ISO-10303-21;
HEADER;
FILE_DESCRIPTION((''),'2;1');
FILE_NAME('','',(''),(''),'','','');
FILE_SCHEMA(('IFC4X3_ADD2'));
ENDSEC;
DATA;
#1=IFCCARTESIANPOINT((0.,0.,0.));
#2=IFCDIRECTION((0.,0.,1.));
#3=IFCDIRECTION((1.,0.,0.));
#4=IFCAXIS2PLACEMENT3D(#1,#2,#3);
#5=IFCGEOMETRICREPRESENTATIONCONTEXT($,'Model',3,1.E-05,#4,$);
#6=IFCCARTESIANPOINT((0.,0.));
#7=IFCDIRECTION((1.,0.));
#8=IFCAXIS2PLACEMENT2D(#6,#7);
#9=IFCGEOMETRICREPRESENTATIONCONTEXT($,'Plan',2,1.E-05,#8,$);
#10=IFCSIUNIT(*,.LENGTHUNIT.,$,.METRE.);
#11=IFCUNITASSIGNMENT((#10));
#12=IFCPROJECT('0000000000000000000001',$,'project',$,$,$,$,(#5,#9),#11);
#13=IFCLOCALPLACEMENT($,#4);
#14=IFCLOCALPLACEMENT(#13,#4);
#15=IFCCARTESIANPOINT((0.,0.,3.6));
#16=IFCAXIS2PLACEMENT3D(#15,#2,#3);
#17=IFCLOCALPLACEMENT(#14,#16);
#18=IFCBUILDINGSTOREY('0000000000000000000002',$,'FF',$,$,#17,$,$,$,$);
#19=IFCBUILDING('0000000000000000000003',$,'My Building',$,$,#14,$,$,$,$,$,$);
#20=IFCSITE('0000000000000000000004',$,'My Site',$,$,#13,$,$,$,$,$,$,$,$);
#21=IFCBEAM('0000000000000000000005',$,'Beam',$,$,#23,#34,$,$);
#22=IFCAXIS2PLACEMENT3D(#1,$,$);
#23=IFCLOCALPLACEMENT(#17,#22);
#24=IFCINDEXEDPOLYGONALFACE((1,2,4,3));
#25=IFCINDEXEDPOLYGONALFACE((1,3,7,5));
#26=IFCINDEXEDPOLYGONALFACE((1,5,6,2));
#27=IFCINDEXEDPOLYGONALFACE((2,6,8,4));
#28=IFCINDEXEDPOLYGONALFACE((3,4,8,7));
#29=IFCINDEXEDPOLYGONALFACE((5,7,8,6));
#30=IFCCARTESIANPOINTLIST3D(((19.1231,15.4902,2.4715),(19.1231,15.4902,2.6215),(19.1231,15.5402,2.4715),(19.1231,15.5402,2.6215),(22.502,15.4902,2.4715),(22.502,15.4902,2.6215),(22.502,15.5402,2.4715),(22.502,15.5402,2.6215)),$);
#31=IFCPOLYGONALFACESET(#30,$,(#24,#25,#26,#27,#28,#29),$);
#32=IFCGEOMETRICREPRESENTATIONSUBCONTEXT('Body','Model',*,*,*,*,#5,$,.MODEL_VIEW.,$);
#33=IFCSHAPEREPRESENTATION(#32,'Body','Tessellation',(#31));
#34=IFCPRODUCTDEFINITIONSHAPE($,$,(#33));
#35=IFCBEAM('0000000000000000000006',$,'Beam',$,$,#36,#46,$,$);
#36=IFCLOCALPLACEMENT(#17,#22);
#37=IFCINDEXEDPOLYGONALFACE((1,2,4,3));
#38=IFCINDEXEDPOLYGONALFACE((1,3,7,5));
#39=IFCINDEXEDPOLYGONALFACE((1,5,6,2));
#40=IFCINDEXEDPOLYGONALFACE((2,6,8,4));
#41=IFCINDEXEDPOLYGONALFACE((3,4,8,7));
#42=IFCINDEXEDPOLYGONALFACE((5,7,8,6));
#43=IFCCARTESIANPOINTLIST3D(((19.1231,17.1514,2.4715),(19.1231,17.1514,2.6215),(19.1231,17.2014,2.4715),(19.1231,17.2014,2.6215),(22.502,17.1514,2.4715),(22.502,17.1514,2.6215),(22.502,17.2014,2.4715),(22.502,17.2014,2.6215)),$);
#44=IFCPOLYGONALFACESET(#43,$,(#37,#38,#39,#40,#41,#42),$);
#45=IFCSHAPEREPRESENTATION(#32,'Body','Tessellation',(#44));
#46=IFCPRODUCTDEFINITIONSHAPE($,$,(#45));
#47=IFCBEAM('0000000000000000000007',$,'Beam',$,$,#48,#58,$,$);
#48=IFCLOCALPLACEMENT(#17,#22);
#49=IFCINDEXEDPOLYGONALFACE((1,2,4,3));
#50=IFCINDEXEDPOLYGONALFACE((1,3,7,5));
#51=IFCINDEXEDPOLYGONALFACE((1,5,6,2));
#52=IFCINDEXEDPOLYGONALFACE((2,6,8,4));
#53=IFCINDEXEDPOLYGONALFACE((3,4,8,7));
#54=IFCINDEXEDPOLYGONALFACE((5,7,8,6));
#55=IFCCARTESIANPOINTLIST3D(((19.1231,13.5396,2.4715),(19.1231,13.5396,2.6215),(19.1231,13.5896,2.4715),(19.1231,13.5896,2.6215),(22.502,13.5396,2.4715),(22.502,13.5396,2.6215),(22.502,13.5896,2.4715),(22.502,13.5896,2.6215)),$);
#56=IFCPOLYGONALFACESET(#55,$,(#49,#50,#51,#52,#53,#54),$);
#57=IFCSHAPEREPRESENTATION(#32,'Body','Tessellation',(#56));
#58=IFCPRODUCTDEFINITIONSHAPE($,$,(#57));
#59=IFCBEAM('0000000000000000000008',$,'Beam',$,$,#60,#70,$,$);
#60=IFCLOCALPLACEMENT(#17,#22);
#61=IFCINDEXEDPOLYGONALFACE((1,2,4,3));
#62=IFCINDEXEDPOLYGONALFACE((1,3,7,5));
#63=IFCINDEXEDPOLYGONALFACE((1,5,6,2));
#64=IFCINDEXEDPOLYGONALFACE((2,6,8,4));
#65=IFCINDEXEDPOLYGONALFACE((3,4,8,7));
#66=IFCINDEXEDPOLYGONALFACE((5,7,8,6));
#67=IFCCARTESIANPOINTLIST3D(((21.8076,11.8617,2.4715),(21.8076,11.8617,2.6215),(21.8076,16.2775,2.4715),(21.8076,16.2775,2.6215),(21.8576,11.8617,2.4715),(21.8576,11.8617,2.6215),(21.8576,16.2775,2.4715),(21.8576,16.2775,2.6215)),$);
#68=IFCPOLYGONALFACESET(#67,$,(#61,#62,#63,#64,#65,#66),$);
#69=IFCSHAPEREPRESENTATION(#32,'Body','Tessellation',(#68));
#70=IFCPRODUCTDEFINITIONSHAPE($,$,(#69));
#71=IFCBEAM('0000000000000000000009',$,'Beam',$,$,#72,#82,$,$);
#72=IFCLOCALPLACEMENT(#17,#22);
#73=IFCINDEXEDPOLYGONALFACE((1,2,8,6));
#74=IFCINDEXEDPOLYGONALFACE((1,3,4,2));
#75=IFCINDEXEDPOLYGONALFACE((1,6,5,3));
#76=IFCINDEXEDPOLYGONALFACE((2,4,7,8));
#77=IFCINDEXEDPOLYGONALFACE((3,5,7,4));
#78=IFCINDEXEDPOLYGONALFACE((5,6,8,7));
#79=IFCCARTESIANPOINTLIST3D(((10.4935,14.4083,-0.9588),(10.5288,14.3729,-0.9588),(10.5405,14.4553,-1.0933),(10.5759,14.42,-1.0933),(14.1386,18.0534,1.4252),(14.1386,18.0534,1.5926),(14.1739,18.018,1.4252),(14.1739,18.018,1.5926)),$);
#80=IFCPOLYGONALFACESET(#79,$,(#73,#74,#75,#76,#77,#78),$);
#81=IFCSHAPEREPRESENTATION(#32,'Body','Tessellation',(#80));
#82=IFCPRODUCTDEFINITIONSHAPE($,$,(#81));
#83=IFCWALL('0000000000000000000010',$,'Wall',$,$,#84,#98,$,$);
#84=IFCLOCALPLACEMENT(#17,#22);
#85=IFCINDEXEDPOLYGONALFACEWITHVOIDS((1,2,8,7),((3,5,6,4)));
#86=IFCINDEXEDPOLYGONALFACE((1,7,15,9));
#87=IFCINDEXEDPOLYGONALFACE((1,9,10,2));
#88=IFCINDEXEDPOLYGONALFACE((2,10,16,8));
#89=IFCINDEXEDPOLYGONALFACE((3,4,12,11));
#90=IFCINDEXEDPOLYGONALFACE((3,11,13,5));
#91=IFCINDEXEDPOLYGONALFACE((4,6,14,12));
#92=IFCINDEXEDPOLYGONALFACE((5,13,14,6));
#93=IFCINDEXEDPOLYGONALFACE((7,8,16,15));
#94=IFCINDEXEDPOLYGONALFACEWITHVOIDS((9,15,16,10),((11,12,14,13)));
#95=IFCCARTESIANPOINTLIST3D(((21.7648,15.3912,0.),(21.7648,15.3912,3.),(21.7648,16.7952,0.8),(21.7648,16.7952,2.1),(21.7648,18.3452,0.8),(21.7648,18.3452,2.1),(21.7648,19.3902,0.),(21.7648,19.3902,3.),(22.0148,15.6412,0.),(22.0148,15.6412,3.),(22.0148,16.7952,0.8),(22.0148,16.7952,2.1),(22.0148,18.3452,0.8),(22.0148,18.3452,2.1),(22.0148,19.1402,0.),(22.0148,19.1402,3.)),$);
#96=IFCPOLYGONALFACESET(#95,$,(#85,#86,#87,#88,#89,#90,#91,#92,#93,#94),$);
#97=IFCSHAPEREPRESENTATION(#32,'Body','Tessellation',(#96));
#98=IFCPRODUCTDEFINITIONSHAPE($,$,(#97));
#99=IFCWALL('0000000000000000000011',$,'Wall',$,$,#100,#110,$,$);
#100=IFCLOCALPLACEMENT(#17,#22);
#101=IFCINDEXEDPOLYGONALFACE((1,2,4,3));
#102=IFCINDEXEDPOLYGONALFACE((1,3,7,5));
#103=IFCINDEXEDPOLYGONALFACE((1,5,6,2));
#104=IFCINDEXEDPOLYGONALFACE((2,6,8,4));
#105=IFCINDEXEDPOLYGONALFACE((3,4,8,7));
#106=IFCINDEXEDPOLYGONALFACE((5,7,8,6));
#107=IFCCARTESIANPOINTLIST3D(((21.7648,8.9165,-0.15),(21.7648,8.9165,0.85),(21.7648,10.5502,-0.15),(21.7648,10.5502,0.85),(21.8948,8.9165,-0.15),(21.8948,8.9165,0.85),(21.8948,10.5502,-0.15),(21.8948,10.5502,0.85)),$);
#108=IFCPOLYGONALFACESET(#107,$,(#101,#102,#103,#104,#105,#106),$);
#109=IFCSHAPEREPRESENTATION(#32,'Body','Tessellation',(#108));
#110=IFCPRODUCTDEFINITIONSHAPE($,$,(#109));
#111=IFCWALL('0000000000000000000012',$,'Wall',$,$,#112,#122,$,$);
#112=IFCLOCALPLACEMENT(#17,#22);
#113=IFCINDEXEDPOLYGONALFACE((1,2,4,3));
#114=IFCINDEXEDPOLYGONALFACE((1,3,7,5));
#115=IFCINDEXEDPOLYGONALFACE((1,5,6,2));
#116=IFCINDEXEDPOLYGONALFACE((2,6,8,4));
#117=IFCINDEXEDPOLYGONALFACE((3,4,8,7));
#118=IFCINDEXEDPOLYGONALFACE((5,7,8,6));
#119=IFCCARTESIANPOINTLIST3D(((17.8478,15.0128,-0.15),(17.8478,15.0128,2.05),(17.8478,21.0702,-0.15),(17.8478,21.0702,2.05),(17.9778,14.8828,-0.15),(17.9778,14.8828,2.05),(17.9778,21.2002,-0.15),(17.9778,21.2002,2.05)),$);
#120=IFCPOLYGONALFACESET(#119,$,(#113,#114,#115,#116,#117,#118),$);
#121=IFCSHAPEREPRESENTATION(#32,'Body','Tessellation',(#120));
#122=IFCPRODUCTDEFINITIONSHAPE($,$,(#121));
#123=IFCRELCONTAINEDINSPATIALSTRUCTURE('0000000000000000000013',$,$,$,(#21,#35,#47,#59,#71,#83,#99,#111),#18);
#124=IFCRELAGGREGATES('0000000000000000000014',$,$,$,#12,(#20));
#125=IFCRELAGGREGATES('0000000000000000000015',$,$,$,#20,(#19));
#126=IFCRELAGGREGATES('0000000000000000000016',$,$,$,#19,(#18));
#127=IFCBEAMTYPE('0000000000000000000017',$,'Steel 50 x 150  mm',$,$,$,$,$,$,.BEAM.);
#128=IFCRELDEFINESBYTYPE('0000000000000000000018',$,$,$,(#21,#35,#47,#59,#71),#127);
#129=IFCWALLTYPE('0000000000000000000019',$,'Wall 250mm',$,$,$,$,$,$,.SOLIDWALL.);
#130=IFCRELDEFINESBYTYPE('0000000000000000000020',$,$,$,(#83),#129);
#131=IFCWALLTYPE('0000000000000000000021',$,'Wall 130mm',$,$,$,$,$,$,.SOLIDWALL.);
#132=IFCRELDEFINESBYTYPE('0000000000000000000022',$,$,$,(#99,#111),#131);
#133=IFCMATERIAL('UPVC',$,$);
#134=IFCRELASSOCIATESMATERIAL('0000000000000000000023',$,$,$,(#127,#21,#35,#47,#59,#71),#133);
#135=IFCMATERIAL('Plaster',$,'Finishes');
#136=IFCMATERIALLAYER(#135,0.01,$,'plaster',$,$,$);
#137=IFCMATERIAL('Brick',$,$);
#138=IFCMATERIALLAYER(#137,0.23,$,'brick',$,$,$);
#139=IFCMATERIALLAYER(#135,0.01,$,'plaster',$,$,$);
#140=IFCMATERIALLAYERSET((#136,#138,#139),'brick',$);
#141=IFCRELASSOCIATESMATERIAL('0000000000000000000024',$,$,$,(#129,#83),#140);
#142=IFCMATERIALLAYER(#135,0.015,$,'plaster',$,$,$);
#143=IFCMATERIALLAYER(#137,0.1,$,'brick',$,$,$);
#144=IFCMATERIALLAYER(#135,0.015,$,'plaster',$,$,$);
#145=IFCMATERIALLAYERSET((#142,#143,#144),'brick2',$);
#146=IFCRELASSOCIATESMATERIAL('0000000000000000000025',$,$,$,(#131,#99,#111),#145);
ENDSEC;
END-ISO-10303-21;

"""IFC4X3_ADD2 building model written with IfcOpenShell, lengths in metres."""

from ifc_helpers import new_model, si_unit, frame, origin_with_axes, origin_2d_with_axis, place, context, subcontext, project, spatial, line, indexed_curve, rectangle, outline, extrude, clip, halfspace, source, transform, mapped, material, layer, layer_set, layer_usage, material_profile, profile_set, profile_usage, type_object, element, save


model = new_model("IFC4X3_ADD2")

# Units and contexts
model_context = context("Model", 3, precision=1e-05, world=origin_with_axes())
plan_context = context("Plan", 2, precision=1e-05, world=origin_2d_with_axis())
body_context = subcontext(model_context, "Body", "Model", "MODEL_VIEW")
ifc_project = project(units=[si_unit("LENGTHUNIT", "METRE")], contexts=[model_context, plan_context])

# Site, building, storey
site_placement = place(None, origin_with_axes())
site = spatial("IfcSite", under=ifc_project, at=site_placement, Name="My Site")
building_placement = place(site_placement, origin_with_axes())
building = spatial("IfcBuilding", under=site, at=building_placement, Name="My Building")
storey_placement = place(building_placement, frame((0.0, 0.0, 3.6), z_axis=(0.0, 0.0, 1.0), x_axis=(1.0, 0.0, 0.0)))
storey = spatial("IfcBuildingStorey", under=building, at=storey_placement, Name="FF")

# Beams
ifc_material_1 = material(Name="UPVC")
ifc_material_profile = material_profile(ifc_material_1, rectangle(XDim=0.05, YDim=0.15))
ifc_profile_set = profile_set([ifc_material_profile])
beam_type = type_object("IfcBeamType", Name="Steel 50 x 150  mm", PredefinedType="BEAM", material=ifc_profile_set)
ifc_profile_usage_1 = profile_usage(ifc_profile_set)
beam_1_placement = place(storey_placement, frame((19.1231, 15.5152, 2.5465), z_axis=(1.0, 0.0, 0.0), x_axis=(0.0, 1.0, 0.0)))
element("IfcBeam", 1, at=beam_1_placement, inside=storey, type_object=beam_type, material=ifc_profile_usage_1, Name="Beam", context=body_context, shape_type="SweptSolid", body=[
    extrude(rectangle(XDim=0.05, YDim=0.15), origin_with_axes(), (0.0, 0.0, 1.0), 3.3789),
])
ifc_profile_usage_2 = profile_usage(ifc_profile_set)
beam_2_placement = place(storey_placement, frame((19.1231, 17.1764, 2.5465), z_axis=(1.0, 0.0, 0.0), x_axis=(0.0, 1.0, 0.0)))
element("IfcBeam", 2, at=beam_2_placement, inside=storey, type_object=beam_type, material=ifc_profile_usage_2, Name="Beam", context=body_context, shape_type="SweptSolid", body=[
    extrude(rectangle(XDim=0.05, YDim=0.15), origin_with_axes(), (0.0, 0.0, 1.0), 3.3789),
])
ifc_profile_usage_3 = profile_usage(ifc_profile_set)
beam_3_placement = place(storey_placement, frame((19.1231, 13.5646, 2.5465), z_axis=(1.0, 0.0, 0.0), x_axis=(0.0, 1.0, 0.0)))
element("IfcBeam", 3, at=beam_3_placement, inside=storey, type_object=beam_type, material=ifc_profile_usage_3, Name="Beam", context=body_context, shape_type="SweptSolid", body=[
    extrude(rectangle(XDim=0.05, YDim=0.15), origin_with_axes(), (0.0, 0.0, 1.0), 3.3789),
])
ifc_profile_usage_4 = profile_usage(ifc_profile_set)
beam_4_placement = place(storey_placement, frame((21.8326, 11.8617, 2.5465), z_axis=(0.0, 1.0, 0.0), x_axis=(-1.0, 0.0, 0.0)))
element("IfcBeam", 4, at=beam_4_placement, inside=storey, type_object=beam_type, material=ifc_profile_usage_4, Name="Beam", context=body_context, shape_type="SweptSolid", body=[
    extrude(rectangle(XDim=0.05, YDim=0.15), origin_with_axes(), (0.0, 0.0, 1.0), 4.4158),
])
ifc_profile_usage_5 = profile_usage(ifc_profile_set)
beam_5_placement = place(storey_placement, frame((10.5347, 14.4141, -1.0261), z_axis=(0.63373, 0.633729, 0.443593), x_axis=(-0.707106, 0.707107, 0.0)))
element("IfcBeam", 5, at=beam_5_placement, inside=storey, type_object=beam_type, material=ifc_profile_usage_5, Name="Beam", context=body_context, shape_type="Clipping", body=[
    clip(extrude(rectangle(XDim=0.05, YDim=0.15), origin_with_axes(), (0.0, 0.0, 1.0), 5.8647), halfspace(frame((5.1339, -2.2719, 4.5902), z_axis=(0.0, -0.443593, 0.896229), x_axis=(-1.0, 0.0, 0.0)), False)),
])

# Wall, opening
ifc_material_2 = material(Name="Plaster", Category="Finishes")
ifc_layer_1 = layer(ifc_material_2, 0.01, Name="plaster")
ifc_material_3 = material(Name="Brick")
ifc_layer_2 = layer(ifc_material_3, 0.23, Name="brick")
ifc_layer_3 = layer(ifc_material_2, 0.01, Name="plaster")
ifc_layer_set_1 = layer_set([ifc_layer_1, ifc_layer_2, ifc_layer_3], Name="brick")
ifc_layer_usage_1 = layer_usage(ifc_layer_set_1, "AXIS2", "NEGATIVE", 0.0)
wall_type_1 = type_object("IfcWallType", Name="Wall 250mm", PredefinedType="SOLIDWALL", material=ifc_layer_set_1)
wall_1_placement = place(storey_placement, frame((21.7648, 15.3912, 0.0), z_axis=(0.0, 0.0, 1.0), x_axis=(0.000001, 1.0, 0.0)))
wall_1 = element("IfcWall", 6, at=wall_1_placement, inside=storey, type_object=wall_type_1, material=ifc_layer_usage_1, Name="Wall", context=body_context, shape_type="SweptSolid", body=[
    extrude(outline(indexed_curve([(0.25, -0.25), (0.0, 0.0), (3.999, 0.0), (3.749, -0.25)], segments=[line(1, 2, 3, 4, 1)])), origin_with_axes(), (0.0, 0.0, 1.0), 3.0),
])
shared_shape = source(origin_with_axes(), body_context, "Body", "SweptSolid", [
    extrude(outline(indexed_curve([(0.0, 0.0), (1.55, 0.0), (1.55, 1.3), (0.0, 1.3)], segments=[line(1, 2, 3, 4, 1)])), frame((-0.775, -0.6, 0.0), z_axis=(0.0, -1.0, 0.0), x_axis=(1.0, 0.0, 0.0)), (0.0, 0.0, -1.0), 1.2),
])
opening_placement = place(wall_1_placement, frame((2.179, 0.0, 0.8), z_axis=(0.0, 0.0, 1.0), x_axis=(1.0, 0.0, 0.0)))
element("IfcOpeningElement", 7, at=opening_placement, cuts=wall_1, PredefinedType="OPENING", context=body_context, shape_type="MappedRepresentation", body=[
    mapped(shared_shape, transform((0.0, 0.0, 0.0), x_axis=(1.0, 0.0, 0.0), y_axis=(0.0, 1.0, 0.0), z_axis=(0.0, 0.0, 1.0), scale=1.0)),
])

# Walls
ifc_layer_4 = layer(ifc_material_2, 0.015, Name="plaster")
ifc_layer_5 = layer(ifc_material_3, 0.1, Name="brick")
ifc_layer_6 = layer(ifc_material_2, 0.015, Name="plaster")
ifc_layer_set_2 = layer_set([ifc_layer_4, ifc_layer_5, ifc_layer_6], Name="brick2")
ifc_layer_usage_2 = layer_usage(ifc_layer_set_2, "AXIS2", "POSITIVE", 0.0)
wall_type_2 = type_object("IfcWallType", Name="Wall 130mm", PredefinedType="SOLIDWALL", material=ifc_layer_set_2)
wall_2_placement = place(storey_placement, frame((21.7648, 10.5502, -0.15), z_axis=(0.0, 0.0, 1.0), x_axis=(0.0, -1.0, 0.0)))
element("IfcWall", 8, at=wall_2_placement, inside=storey, type_object=wall_type_2, material=ifc_layer_usage_2, Name="Wall", context=body_context, shape_type="SweptSolid", body=[
    extrude(outline(indexed_curve([(0.0, 0.0), (0.0, 0.13), (1.6337, 0.13), (1.6337, 0.0)], segments=[line(1, 2, 3, 4, 1)])), origin_with_axes(), (0.0, 0.0, 1.0), 1.0),
])
ifc_layer_usage_3 = layer_usage(ifc_layer_set_2, "AXIS2", "POSITIVE", 0.0)
wall_3_placement = place(storey_placement, frame((17.9778, 15.0128, -0.15), z_axis=(0.0, 0.0, 1.0), x_axis=(0.000001, 1.0, 0.0)))
element("IfcWall", 9, at=wall_3_placement, inside=storey, type_object=wall_type_2, material=ifc_layer_usage_3, Name="Wall", context=body_context, shape_type="SweptSolid", body=[
    extrude(outline(indexed_curve([(-0.13, 0.0), (0.0, 0.13), (6.0575, 0.13), (6.1875, 0.0)], segments=[line(1, 2, 3, 4, 1)])), origin_with_axes(), (0.0, 0.0, 1.0), 2.2),
])

save(model, "model.ifc")
